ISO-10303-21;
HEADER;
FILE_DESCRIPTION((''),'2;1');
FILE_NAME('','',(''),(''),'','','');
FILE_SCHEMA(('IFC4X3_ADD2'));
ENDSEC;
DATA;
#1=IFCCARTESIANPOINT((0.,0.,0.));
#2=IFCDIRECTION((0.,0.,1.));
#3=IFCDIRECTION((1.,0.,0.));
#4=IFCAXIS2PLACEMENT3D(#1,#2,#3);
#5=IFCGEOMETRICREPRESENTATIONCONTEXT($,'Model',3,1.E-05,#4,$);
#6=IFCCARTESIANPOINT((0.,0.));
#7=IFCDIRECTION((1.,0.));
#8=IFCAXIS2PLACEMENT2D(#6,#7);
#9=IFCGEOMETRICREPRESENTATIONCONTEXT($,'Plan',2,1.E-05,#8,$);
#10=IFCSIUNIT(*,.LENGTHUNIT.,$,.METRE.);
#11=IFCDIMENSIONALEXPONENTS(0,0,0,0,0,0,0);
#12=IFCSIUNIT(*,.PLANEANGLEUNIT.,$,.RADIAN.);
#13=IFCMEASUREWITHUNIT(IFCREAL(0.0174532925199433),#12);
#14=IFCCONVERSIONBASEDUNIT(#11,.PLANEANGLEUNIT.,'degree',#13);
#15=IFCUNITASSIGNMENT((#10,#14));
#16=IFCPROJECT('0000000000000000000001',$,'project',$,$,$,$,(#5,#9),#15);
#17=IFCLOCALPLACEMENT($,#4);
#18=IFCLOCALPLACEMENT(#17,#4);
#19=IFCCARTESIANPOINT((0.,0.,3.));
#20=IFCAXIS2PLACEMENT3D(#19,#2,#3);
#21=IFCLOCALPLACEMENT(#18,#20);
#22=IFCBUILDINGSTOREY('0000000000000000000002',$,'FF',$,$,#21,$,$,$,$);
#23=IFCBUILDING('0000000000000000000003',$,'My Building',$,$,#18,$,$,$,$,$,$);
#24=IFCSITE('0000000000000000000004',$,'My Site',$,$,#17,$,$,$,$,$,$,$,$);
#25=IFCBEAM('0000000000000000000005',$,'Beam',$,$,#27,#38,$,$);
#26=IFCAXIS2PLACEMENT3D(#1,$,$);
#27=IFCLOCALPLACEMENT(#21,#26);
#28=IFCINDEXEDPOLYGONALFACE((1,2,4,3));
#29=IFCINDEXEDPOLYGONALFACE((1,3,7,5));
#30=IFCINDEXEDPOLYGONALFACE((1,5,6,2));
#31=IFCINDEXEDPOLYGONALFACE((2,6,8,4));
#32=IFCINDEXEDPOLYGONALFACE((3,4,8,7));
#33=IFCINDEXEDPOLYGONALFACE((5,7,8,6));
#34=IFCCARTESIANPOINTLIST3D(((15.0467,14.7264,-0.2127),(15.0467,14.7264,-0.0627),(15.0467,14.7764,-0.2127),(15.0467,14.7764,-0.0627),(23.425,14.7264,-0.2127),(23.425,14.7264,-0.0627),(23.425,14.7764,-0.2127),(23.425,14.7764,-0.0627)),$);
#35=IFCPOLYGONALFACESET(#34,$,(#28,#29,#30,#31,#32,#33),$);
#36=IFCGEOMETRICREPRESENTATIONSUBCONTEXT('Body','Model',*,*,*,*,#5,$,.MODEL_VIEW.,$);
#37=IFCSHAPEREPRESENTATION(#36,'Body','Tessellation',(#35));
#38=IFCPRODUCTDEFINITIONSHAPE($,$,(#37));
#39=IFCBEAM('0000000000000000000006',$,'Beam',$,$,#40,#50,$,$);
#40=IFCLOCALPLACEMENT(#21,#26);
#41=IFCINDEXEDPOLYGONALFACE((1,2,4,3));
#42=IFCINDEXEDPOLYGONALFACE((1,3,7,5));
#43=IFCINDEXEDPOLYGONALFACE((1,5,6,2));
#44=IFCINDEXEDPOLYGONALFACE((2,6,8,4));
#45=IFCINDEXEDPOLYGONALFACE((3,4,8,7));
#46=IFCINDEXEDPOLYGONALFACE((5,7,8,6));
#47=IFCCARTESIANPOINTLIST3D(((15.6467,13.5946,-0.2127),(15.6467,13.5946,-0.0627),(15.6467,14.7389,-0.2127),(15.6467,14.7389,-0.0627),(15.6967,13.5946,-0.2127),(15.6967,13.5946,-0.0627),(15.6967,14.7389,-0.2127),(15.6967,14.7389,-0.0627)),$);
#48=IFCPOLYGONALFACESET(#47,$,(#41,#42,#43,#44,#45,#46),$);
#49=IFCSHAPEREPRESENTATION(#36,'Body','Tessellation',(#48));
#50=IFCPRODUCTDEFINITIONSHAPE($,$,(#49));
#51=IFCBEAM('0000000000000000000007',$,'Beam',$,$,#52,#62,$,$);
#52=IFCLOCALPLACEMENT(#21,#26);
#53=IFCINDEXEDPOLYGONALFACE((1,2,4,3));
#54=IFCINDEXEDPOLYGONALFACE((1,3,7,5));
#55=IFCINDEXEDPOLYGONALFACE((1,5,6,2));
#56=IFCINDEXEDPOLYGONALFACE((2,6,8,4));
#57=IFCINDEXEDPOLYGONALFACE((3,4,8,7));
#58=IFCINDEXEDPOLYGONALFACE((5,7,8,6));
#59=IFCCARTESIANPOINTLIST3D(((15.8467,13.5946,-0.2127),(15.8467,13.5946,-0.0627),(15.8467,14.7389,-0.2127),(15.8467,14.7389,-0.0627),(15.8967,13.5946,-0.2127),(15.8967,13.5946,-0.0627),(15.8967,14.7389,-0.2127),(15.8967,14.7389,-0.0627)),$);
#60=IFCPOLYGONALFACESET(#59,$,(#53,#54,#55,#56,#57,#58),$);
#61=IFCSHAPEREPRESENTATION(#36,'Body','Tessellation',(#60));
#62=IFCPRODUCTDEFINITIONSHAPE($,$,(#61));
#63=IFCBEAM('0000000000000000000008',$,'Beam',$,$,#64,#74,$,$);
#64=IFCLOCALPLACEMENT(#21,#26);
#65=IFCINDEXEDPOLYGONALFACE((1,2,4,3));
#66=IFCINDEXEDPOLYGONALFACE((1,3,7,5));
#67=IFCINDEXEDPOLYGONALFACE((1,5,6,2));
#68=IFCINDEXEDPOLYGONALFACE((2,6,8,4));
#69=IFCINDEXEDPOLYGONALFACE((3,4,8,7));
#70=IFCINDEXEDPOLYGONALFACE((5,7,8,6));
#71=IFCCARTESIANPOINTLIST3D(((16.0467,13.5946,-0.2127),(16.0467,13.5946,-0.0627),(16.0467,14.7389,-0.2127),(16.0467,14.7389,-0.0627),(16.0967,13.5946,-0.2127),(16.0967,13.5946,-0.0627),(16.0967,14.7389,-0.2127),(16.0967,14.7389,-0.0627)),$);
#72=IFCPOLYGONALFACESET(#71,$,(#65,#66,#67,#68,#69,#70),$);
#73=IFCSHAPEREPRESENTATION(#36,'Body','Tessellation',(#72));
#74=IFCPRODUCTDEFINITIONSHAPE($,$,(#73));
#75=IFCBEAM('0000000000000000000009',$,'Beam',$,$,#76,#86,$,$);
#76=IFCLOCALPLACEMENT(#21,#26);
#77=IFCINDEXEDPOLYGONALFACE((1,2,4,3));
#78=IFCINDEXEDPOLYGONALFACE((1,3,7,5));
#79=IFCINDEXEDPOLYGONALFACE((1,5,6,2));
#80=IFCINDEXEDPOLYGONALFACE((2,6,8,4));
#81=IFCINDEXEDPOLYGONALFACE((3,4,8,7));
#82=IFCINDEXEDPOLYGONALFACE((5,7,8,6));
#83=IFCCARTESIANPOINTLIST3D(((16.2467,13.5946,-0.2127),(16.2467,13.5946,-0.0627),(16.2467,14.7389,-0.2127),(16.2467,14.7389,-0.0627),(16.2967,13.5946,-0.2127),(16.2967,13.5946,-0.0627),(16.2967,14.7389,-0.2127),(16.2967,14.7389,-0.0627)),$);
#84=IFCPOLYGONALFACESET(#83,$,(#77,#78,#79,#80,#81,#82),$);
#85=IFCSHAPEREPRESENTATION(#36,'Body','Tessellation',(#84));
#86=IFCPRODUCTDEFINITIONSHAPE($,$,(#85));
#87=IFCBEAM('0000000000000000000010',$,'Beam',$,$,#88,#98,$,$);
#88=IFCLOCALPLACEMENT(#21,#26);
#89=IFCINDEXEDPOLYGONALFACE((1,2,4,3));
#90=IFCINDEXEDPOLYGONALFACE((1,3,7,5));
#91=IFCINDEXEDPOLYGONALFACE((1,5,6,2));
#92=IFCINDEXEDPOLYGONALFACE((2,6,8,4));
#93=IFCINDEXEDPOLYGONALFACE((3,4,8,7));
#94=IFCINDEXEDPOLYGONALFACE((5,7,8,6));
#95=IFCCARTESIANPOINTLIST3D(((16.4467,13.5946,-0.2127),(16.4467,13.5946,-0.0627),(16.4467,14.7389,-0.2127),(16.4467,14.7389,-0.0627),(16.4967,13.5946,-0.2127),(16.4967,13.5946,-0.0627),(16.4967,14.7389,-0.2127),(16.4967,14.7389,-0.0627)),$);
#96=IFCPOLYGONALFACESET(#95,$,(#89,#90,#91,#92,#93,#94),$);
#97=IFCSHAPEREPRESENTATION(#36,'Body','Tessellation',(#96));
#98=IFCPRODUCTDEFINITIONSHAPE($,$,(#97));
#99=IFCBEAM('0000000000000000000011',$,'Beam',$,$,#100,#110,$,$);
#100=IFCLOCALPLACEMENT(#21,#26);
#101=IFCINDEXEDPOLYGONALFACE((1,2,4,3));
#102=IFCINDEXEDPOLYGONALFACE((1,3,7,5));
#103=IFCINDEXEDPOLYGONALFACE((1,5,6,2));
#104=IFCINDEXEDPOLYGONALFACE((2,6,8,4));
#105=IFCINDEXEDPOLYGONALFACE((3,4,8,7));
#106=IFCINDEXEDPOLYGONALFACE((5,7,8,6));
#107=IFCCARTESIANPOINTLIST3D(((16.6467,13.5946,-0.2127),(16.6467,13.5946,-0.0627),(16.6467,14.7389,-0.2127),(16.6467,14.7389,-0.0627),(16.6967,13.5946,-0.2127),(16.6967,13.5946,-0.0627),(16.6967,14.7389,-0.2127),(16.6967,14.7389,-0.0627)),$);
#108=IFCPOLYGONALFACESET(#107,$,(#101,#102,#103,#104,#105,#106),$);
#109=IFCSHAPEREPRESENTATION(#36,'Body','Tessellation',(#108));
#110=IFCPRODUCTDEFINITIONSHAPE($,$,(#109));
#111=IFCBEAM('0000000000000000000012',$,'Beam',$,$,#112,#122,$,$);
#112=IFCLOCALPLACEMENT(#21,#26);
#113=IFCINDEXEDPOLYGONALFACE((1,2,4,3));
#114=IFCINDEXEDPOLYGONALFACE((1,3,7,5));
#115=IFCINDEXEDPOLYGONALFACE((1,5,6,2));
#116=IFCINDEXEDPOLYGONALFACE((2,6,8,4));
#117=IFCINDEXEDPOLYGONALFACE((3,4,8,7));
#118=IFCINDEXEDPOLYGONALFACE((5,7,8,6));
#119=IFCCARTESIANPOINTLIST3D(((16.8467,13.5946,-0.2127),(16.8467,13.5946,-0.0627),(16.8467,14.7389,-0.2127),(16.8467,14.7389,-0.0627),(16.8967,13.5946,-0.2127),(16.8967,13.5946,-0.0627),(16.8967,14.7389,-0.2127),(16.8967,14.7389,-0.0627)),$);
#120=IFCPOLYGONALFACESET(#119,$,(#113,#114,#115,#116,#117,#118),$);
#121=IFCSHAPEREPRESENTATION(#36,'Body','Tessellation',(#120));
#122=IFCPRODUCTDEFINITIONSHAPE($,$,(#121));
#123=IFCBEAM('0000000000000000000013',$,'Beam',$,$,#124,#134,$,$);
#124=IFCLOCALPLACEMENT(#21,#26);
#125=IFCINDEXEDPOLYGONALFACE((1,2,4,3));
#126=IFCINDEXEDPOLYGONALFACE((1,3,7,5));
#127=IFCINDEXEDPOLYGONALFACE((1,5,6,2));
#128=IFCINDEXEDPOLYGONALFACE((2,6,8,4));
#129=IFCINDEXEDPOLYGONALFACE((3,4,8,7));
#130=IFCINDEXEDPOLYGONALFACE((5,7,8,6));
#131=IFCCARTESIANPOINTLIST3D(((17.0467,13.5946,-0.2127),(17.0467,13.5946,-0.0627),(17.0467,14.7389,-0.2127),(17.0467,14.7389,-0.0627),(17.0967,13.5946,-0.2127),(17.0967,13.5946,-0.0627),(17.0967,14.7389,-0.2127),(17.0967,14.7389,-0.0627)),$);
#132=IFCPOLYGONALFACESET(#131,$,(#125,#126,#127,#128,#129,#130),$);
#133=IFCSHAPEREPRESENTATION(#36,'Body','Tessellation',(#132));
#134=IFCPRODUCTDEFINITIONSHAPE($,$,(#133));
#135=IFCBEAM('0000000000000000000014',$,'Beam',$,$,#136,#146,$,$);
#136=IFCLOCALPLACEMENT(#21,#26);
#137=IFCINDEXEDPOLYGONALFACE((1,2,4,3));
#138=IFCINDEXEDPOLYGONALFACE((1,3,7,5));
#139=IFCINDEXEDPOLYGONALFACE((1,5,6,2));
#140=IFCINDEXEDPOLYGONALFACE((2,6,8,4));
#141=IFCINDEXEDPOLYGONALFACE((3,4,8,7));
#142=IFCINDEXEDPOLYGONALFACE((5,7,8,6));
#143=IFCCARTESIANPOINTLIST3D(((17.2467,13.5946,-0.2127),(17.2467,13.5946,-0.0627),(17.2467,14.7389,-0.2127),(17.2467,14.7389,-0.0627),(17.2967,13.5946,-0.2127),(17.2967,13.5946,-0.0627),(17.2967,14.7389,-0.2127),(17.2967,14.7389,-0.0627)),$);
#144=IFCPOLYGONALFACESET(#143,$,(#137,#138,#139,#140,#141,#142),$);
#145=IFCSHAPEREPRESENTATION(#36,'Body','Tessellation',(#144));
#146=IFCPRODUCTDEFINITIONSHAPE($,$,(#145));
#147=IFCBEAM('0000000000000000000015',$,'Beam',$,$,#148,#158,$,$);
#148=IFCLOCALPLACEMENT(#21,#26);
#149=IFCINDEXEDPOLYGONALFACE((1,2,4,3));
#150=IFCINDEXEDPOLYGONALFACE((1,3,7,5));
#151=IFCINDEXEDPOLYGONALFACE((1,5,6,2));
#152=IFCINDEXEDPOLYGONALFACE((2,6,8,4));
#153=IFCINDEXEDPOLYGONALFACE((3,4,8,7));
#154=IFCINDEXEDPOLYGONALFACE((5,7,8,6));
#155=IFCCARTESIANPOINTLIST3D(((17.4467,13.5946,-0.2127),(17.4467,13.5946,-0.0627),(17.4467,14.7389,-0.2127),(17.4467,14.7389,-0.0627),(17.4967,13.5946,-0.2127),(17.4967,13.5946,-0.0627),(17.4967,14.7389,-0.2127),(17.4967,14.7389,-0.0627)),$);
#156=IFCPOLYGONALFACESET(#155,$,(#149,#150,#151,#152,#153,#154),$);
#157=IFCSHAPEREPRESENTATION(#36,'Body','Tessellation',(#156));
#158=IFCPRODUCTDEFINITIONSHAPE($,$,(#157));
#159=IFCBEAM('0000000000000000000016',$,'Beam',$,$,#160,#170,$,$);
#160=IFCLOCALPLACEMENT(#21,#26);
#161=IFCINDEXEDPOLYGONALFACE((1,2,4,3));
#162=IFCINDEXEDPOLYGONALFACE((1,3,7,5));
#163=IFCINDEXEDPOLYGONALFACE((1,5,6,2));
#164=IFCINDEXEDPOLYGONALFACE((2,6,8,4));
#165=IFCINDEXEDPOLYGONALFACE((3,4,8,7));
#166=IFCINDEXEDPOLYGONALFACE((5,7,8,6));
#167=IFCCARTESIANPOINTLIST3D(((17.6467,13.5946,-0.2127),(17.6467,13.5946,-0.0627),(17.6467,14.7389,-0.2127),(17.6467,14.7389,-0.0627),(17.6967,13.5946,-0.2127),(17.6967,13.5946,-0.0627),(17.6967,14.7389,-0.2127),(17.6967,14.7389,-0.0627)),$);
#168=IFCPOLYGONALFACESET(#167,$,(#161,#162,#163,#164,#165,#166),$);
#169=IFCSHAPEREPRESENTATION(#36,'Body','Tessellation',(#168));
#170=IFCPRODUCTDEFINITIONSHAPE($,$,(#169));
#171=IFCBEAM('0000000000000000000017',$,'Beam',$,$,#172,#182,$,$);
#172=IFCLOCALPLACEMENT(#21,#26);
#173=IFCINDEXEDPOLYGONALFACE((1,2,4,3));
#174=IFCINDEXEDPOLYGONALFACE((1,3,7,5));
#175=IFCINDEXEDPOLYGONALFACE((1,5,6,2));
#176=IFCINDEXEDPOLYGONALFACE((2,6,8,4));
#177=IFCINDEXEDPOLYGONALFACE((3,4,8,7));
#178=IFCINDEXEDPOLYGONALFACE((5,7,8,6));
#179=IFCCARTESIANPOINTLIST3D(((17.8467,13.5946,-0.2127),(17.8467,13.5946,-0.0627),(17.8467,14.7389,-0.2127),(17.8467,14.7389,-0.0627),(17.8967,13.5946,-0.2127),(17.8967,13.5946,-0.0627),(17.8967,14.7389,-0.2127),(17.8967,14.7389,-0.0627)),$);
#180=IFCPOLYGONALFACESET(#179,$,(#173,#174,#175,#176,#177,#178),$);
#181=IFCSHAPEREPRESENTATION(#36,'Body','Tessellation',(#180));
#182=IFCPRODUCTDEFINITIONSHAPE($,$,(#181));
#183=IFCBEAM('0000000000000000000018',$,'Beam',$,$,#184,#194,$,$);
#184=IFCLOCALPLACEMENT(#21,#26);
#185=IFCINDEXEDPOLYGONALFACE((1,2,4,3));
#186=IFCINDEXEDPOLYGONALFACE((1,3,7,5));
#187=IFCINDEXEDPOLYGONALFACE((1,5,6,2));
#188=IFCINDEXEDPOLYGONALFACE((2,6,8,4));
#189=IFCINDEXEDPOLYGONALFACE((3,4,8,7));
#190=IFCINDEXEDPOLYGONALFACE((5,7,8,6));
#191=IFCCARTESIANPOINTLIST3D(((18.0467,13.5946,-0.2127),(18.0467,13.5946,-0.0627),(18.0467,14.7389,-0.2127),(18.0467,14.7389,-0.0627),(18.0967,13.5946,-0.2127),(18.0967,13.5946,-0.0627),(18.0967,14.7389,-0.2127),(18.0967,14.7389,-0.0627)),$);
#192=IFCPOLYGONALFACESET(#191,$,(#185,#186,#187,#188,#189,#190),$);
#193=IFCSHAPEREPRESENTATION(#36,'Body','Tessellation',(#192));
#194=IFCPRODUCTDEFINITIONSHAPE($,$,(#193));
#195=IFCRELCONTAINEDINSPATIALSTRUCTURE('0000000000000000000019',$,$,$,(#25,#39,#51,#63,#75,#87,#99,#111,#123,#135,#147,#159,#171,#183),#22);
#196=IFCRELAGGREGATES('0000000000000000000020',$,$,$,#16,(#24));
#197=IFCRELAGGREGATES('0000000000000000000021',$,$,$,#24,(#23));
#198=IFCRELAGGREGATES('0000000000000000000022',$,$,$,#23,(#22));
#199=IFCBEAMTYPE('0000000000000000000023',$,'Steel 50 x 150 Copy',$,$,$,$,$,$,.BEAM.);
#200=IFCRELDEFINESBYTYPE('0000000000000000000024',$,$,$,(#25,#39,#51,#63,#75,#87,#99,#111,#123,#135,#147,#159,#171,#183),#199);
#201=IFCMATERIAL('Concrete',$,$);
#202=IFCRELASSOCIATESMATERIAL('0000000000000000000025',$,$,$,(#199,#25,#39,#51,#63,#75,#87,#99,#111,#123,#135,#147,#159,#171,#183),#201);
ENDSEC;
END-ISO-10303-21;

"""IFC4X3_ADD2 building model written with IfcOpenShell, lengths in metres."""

from ifc_helpers import new_model, entity, si_unit, converted_unit, frame, origin_with_axes, origin_2d_with_axis, place, context, subcontext, project, spatial, rectangle, extrude, material, material_profile, profile_set, profile_usage, type_object, element, save


model = new_model("IFC4X3_ADD2")

# Units and contexts
model_context = context("Model", 3, precision=1e-05, world=origin_with_axes())
plan_context = context("Plan", 2, precision=1e-05, world=origin_2d_with_axis())
body_context = subcontext(model_context, "Body", "Model", "MODEL_VIEW")
ifc_project = project(units=[si_unit("LENGTHUNIT", "METRE"), converted_unit("PLANEANGLEUNIT", "degree", entity("IfcReal", 0.0174532925199433), si_unit("PLANEANGLEUNIT", "RADIAN"), dimensions=[0, 0, 0, 0, 0, 0, 0])], contexts=[model_context, plan_context])

# Site, building, storey
site_placement = place(None, origin_with_axes())
site = spatial("IfcSite", under=ifc_project, at=site_placement, Name="My Site")
building_placement = place(site_placement, origin_with_axes())
building = spatial("IfcBuilding", under=site, at=building_placement, Name="My Building")
storey_placement = place(building_placement, frame((0.0, 0.0, 3.0), z_axis=(0.0, 0.0, 1.0), x_axis=(1.0, 0.0, 0.0)))
storey = spatial("IfcBuildingStorey", under=building, at=storey_placement, Name="FF")

# Beams
ifc_material_1 = material(Name="Concrete")
ifc_material_profile = material_profile(ifc_material_1, rectangle(XDim=0.05, YDim=0.15))
ifc_profile_set = profile_set([ifc_material_profile])
ifc_profile_usage_1 = profile_usage(ifc_profile_set)
beam_type = type_object("IfcBeamType", Name="Steel 50 x 150 Copy", PredefinedType="BEAM", material=ifc_profile_set)
beam_1_placement = place(storey_placement, frame((15.0467, 14.7514, -0.1377), z_axis=(1.0, 0.0, 0.0), x_axis=(0.0, 1.0, 0.0)))
element("IfcBeam", 1, at=beam_1_placement, inside=storey, type_object=beam_type, material=ifc_profile_usage_1, Name="Beam", context=body_context, shape_type="SweptSolid", body=[
    extrude(rectangle(XDim=0.05, YDim=0.15), origin_with_axes(), (0.0, 0.0, 1.0), 8.3783),
])
ifc_profile_usage_2 = profile_usage(ifc_profile_set)
beam_2_placement = place(storey_placement, frame((15.6717, 14.7389, -0.1377), z_axis=(0.0, -1.0, 0.0), x_axis=(1.0, 0.0, 0.0)))
element("IfcBeam", 2, at=beam_2_placement, inside=storey, type_object=beam_type, material=ifc_profile_usage_2, Name="Beam", context=body_context, shape_type="SweptSolid", body=[
    extrude(rectangle(XDim=0.05, YDim=0.15), origin_with_axes(), (0.0, 0.0, 1.0), 1.1444),
])
ifc_profile_usage_3 = profile_usage(ifc_profile_set)
beam_3_placement = place(storey_placement, frame((15.8717, 14.7389, -0.1377), z_axis=(0.0, -1.0, 0.0), x_axis=(1.0, 0.0, 0.0)))
element("IfcBeam", 3, at=beam_3_placement, inside=storey, type_object=beam_type, material=ifc_profile_usage_3, Name="Beam", context=body_context, shape_type="SweptSolid", body=[
    extrude(rectangle(XDim=0.05, YDim=0.15), origin_with_axes(), (0.0, 0.0, 1.0), 1.1444),
])
ifc_profile_usage_4 = profile_usage(ifc_profile_set)
beam_4_placement = place(storey_placement, frame((16.0717, 14.7389, -0.1377), z_axis=(0.0, -1.0, 0.0), x_axis=(1.0, 0.0, 0.0)))
element("IfcBeam", 4, at=beam_4_placement, inside=storey, type_object=beam_type, material=ifc_profile_usage_4, Name="Beam", context=body_context, shape_type="SweptSolid", body=[
    extrude(rectangle(XDim=0.05, YDim=0.15), origin_with_axes(), (0.0, 0.0, 1.0), 1.1444),
])
ifc_profile_usage_5 = profile_usage(ifc_profile_set)
beam_5_placement = place(storey_placement, frame((16.2717, 14.7389, -0.1377), z_axis=(0.0, -1.0, 0.0), x_axis=(1.0, 0.0, 0.0)))
element("IfcBeam", 5, at=beam_5_placement, inside=storey, type_object=beam_type, material=ifc_profile_usage_5, Name="Beam", context=body_context, shape_type="SweptSolid", body=[
    extrude(rectangle(XDim=0.05, YDim=0.15), origin_with_axes(), (0.0, 0.0, 1.0), 1.1444),
])
ifc_profile_usage_6 = profile_usage(ifc_profile_set)
beam_6_placement = place(storey_placement, frame((16.4717, 14.7389, -0.1377), z_axis=(0.0, -1.0, 0.0), x_axis=(1.0, 0.0, 0.0)))
element("IfcBeam", 6, at=beam_6_placement, inside=storey, type_object=beam_type, material=ifc_profile_usage_6, Name="Beam", context=body_context, shape_type="SweptSolid", body=[
    extrude(rectangle(XDim=0.05, YDim=0.15), origin_with_axes(), (0.0, 0.0, 1.0), 1.1444),
])
ifc_profile_usage_7 = profile_usage(ifc_profile_set)
beam_7_placement = place(storey_placement, frame((16.6717, 14.7389, -0.1377), z_axis=(0.0, -1.0, 0.0), x_axis=(1.0, 0.0, 0.0)))
element("IfcBeam", 7, at=beam_7_placement, inside=storey, type_object=beam_type, material=ifc_profile_usage_7, Name="Beam", context=body_context, shape_type="SweptSolid", body=[
    extrude(rectangle(XDim=0.05, YDim=0.15), origin_with_axes(), (0.0, 0.0, 1.0), 1.1444),
])
ifc_profile_usage_8 = profile_usage(ifc_profile_set)
beam_8_placement = place(storey_placement, frame((16.8717, 14.7389, -0.1377), z_axis=(0.0, -1.0, 0.0), x_axis=(1.0, 0.0, 0.0)))
element("IfcBeam", 8, at=beam_8_placement, inside=storey, type_object=beam_type, material=ifc_profile_usage_8, Name="Beam", context=body_context, shape_type="SweptSolid", body=[
    extrude(rectangle(XDim=0.05, YDim=0.15), origin_with_axes(), (0.0, 0.0, 1.0), 1.1444),
])
ifc_profile_usage_9 = profile_usage(ifc_profile_set)
beam_9_placement = place(storey_placement, frame((17.0717, 14.7389, -0.1377), z_axis=(0.0, -1.0, 0.0), x_axis=(1.0, 0.0, 0.0)))
element("IfcBeam", 9, at=beam_9_placement, inside=storey, type_object=beam_type, material=ifc_profile_usage_9, Name="Beam", context=body_context, shape_type="SweptSolid", body=[
    extrude(rectangle(XDim=0.05, YDim=0.15), origin_with_axes(), (0.0, 0.0, 1.0), 1.1444),
])
ifc_profile_usage_10 = profile_usage(ifc_profile_set)
beam_10_placement = place(storey_placement, frame((17.2717, 14.7389, -0.1377), z_axis=(0.0, -1.0, 0.0), x_axis=(1.0, 0.0, 0.0)))
element("IfcBeam", 10, at=beam_10_placement, inside=storey, type_object=beam_type, material=ifc_profile_usage_10, Name="Beam", context=body_context, shape_type="SweptSolid", body=[
    extrude(rectangle(XDim=0.05, YDim=0.15), origin_with_axes(), (0.0, 0.0, 1.0), 1.1444),
])
ifc_profile_usage_11 = profile_usage(ifc_profile_set)
beam_11_placement = place(storey_placement, frame((17.4717, 14.7389, -0.1377), z_axis=(0.0, -1.0, 0.0), x_axis=(1.0, 0.0, 0.0)))
element("IfcBeam", 11, at=beam_11_placement, inside=storey, type_object=beam_type, material=ifc_profile_usage_11, Name="Beam", context=body_context, shape_type="SweptSolid", body=[
    extrude(rectangle(XDim=0.05, YDim=0.15), origin_with_axes(), (0.0, 0.0, 1.0), 1.1444),
])
ifc_profile_usage_12 = profile_usage(ifc_profile_set)
beam_12_placement = place(storey_placement, frame((17.6717, 14.7389, -0.1377), z_axis=(0.0, -1.0, 0.0), x_axis=(1.0, 0.0, 0.0)))
element("IfcBeam", 12, at=beam_12_placement, inside=storey, type_object=beam_type, material=ifc_profile_usage_12, Name="Beam", context=body_context, shape_type="SweptSolid", body=[
    extrude(rectangle(XDim=0.05, YDim=0.15), origin_with_axes(), (0.0, 0.0, 1.0), 1.1444),
])
ifc_profile_usage_13 = profile_usage(ifc_profile_set)
beam_13_placement = place(storey_placement, frame((17.8717, 14.7389, -0.1377), z_axis=(0.0, -1.0, 0.0), x_axis=(1.0, 0.0, 0.0)))
element("IfcBeam", 13, at=beam_13_placement, inside=storey, type_object=beam_type, material=ifc_profile_usage_13, Name="Beam", context=body_context, shape_type="SweptSolid", body=[
    extrude(rectangle(XDim=0.05, YDim=0.15), origin_with_axes(), (0.0, 0.0, 1.0), 1.1444),
])
ifc_profile_usage_14 = profile_usage(ifc_profile_set)
beam_14_placement = place(storey_placement, frame((18.0717, 14.7389, -0.1377), z_axis=(0.0, -1.0, 0.0), x_axis=(1.0, 0.0, 0.0)))
element("IfcBeam", 14, at=beam_14_placement, inside=storey, type_object=beam_type, material=ifc_profile_usage_14, Name="Beam", context=body_context, shape_type="SweptSolid", body=[
    extrude(rectangle(XDim=0.05, YDim=0.15), origin_with_axes(), (0.0, 0.0, 1.0), 1.1444),
])

save(model, "model.ifc")
